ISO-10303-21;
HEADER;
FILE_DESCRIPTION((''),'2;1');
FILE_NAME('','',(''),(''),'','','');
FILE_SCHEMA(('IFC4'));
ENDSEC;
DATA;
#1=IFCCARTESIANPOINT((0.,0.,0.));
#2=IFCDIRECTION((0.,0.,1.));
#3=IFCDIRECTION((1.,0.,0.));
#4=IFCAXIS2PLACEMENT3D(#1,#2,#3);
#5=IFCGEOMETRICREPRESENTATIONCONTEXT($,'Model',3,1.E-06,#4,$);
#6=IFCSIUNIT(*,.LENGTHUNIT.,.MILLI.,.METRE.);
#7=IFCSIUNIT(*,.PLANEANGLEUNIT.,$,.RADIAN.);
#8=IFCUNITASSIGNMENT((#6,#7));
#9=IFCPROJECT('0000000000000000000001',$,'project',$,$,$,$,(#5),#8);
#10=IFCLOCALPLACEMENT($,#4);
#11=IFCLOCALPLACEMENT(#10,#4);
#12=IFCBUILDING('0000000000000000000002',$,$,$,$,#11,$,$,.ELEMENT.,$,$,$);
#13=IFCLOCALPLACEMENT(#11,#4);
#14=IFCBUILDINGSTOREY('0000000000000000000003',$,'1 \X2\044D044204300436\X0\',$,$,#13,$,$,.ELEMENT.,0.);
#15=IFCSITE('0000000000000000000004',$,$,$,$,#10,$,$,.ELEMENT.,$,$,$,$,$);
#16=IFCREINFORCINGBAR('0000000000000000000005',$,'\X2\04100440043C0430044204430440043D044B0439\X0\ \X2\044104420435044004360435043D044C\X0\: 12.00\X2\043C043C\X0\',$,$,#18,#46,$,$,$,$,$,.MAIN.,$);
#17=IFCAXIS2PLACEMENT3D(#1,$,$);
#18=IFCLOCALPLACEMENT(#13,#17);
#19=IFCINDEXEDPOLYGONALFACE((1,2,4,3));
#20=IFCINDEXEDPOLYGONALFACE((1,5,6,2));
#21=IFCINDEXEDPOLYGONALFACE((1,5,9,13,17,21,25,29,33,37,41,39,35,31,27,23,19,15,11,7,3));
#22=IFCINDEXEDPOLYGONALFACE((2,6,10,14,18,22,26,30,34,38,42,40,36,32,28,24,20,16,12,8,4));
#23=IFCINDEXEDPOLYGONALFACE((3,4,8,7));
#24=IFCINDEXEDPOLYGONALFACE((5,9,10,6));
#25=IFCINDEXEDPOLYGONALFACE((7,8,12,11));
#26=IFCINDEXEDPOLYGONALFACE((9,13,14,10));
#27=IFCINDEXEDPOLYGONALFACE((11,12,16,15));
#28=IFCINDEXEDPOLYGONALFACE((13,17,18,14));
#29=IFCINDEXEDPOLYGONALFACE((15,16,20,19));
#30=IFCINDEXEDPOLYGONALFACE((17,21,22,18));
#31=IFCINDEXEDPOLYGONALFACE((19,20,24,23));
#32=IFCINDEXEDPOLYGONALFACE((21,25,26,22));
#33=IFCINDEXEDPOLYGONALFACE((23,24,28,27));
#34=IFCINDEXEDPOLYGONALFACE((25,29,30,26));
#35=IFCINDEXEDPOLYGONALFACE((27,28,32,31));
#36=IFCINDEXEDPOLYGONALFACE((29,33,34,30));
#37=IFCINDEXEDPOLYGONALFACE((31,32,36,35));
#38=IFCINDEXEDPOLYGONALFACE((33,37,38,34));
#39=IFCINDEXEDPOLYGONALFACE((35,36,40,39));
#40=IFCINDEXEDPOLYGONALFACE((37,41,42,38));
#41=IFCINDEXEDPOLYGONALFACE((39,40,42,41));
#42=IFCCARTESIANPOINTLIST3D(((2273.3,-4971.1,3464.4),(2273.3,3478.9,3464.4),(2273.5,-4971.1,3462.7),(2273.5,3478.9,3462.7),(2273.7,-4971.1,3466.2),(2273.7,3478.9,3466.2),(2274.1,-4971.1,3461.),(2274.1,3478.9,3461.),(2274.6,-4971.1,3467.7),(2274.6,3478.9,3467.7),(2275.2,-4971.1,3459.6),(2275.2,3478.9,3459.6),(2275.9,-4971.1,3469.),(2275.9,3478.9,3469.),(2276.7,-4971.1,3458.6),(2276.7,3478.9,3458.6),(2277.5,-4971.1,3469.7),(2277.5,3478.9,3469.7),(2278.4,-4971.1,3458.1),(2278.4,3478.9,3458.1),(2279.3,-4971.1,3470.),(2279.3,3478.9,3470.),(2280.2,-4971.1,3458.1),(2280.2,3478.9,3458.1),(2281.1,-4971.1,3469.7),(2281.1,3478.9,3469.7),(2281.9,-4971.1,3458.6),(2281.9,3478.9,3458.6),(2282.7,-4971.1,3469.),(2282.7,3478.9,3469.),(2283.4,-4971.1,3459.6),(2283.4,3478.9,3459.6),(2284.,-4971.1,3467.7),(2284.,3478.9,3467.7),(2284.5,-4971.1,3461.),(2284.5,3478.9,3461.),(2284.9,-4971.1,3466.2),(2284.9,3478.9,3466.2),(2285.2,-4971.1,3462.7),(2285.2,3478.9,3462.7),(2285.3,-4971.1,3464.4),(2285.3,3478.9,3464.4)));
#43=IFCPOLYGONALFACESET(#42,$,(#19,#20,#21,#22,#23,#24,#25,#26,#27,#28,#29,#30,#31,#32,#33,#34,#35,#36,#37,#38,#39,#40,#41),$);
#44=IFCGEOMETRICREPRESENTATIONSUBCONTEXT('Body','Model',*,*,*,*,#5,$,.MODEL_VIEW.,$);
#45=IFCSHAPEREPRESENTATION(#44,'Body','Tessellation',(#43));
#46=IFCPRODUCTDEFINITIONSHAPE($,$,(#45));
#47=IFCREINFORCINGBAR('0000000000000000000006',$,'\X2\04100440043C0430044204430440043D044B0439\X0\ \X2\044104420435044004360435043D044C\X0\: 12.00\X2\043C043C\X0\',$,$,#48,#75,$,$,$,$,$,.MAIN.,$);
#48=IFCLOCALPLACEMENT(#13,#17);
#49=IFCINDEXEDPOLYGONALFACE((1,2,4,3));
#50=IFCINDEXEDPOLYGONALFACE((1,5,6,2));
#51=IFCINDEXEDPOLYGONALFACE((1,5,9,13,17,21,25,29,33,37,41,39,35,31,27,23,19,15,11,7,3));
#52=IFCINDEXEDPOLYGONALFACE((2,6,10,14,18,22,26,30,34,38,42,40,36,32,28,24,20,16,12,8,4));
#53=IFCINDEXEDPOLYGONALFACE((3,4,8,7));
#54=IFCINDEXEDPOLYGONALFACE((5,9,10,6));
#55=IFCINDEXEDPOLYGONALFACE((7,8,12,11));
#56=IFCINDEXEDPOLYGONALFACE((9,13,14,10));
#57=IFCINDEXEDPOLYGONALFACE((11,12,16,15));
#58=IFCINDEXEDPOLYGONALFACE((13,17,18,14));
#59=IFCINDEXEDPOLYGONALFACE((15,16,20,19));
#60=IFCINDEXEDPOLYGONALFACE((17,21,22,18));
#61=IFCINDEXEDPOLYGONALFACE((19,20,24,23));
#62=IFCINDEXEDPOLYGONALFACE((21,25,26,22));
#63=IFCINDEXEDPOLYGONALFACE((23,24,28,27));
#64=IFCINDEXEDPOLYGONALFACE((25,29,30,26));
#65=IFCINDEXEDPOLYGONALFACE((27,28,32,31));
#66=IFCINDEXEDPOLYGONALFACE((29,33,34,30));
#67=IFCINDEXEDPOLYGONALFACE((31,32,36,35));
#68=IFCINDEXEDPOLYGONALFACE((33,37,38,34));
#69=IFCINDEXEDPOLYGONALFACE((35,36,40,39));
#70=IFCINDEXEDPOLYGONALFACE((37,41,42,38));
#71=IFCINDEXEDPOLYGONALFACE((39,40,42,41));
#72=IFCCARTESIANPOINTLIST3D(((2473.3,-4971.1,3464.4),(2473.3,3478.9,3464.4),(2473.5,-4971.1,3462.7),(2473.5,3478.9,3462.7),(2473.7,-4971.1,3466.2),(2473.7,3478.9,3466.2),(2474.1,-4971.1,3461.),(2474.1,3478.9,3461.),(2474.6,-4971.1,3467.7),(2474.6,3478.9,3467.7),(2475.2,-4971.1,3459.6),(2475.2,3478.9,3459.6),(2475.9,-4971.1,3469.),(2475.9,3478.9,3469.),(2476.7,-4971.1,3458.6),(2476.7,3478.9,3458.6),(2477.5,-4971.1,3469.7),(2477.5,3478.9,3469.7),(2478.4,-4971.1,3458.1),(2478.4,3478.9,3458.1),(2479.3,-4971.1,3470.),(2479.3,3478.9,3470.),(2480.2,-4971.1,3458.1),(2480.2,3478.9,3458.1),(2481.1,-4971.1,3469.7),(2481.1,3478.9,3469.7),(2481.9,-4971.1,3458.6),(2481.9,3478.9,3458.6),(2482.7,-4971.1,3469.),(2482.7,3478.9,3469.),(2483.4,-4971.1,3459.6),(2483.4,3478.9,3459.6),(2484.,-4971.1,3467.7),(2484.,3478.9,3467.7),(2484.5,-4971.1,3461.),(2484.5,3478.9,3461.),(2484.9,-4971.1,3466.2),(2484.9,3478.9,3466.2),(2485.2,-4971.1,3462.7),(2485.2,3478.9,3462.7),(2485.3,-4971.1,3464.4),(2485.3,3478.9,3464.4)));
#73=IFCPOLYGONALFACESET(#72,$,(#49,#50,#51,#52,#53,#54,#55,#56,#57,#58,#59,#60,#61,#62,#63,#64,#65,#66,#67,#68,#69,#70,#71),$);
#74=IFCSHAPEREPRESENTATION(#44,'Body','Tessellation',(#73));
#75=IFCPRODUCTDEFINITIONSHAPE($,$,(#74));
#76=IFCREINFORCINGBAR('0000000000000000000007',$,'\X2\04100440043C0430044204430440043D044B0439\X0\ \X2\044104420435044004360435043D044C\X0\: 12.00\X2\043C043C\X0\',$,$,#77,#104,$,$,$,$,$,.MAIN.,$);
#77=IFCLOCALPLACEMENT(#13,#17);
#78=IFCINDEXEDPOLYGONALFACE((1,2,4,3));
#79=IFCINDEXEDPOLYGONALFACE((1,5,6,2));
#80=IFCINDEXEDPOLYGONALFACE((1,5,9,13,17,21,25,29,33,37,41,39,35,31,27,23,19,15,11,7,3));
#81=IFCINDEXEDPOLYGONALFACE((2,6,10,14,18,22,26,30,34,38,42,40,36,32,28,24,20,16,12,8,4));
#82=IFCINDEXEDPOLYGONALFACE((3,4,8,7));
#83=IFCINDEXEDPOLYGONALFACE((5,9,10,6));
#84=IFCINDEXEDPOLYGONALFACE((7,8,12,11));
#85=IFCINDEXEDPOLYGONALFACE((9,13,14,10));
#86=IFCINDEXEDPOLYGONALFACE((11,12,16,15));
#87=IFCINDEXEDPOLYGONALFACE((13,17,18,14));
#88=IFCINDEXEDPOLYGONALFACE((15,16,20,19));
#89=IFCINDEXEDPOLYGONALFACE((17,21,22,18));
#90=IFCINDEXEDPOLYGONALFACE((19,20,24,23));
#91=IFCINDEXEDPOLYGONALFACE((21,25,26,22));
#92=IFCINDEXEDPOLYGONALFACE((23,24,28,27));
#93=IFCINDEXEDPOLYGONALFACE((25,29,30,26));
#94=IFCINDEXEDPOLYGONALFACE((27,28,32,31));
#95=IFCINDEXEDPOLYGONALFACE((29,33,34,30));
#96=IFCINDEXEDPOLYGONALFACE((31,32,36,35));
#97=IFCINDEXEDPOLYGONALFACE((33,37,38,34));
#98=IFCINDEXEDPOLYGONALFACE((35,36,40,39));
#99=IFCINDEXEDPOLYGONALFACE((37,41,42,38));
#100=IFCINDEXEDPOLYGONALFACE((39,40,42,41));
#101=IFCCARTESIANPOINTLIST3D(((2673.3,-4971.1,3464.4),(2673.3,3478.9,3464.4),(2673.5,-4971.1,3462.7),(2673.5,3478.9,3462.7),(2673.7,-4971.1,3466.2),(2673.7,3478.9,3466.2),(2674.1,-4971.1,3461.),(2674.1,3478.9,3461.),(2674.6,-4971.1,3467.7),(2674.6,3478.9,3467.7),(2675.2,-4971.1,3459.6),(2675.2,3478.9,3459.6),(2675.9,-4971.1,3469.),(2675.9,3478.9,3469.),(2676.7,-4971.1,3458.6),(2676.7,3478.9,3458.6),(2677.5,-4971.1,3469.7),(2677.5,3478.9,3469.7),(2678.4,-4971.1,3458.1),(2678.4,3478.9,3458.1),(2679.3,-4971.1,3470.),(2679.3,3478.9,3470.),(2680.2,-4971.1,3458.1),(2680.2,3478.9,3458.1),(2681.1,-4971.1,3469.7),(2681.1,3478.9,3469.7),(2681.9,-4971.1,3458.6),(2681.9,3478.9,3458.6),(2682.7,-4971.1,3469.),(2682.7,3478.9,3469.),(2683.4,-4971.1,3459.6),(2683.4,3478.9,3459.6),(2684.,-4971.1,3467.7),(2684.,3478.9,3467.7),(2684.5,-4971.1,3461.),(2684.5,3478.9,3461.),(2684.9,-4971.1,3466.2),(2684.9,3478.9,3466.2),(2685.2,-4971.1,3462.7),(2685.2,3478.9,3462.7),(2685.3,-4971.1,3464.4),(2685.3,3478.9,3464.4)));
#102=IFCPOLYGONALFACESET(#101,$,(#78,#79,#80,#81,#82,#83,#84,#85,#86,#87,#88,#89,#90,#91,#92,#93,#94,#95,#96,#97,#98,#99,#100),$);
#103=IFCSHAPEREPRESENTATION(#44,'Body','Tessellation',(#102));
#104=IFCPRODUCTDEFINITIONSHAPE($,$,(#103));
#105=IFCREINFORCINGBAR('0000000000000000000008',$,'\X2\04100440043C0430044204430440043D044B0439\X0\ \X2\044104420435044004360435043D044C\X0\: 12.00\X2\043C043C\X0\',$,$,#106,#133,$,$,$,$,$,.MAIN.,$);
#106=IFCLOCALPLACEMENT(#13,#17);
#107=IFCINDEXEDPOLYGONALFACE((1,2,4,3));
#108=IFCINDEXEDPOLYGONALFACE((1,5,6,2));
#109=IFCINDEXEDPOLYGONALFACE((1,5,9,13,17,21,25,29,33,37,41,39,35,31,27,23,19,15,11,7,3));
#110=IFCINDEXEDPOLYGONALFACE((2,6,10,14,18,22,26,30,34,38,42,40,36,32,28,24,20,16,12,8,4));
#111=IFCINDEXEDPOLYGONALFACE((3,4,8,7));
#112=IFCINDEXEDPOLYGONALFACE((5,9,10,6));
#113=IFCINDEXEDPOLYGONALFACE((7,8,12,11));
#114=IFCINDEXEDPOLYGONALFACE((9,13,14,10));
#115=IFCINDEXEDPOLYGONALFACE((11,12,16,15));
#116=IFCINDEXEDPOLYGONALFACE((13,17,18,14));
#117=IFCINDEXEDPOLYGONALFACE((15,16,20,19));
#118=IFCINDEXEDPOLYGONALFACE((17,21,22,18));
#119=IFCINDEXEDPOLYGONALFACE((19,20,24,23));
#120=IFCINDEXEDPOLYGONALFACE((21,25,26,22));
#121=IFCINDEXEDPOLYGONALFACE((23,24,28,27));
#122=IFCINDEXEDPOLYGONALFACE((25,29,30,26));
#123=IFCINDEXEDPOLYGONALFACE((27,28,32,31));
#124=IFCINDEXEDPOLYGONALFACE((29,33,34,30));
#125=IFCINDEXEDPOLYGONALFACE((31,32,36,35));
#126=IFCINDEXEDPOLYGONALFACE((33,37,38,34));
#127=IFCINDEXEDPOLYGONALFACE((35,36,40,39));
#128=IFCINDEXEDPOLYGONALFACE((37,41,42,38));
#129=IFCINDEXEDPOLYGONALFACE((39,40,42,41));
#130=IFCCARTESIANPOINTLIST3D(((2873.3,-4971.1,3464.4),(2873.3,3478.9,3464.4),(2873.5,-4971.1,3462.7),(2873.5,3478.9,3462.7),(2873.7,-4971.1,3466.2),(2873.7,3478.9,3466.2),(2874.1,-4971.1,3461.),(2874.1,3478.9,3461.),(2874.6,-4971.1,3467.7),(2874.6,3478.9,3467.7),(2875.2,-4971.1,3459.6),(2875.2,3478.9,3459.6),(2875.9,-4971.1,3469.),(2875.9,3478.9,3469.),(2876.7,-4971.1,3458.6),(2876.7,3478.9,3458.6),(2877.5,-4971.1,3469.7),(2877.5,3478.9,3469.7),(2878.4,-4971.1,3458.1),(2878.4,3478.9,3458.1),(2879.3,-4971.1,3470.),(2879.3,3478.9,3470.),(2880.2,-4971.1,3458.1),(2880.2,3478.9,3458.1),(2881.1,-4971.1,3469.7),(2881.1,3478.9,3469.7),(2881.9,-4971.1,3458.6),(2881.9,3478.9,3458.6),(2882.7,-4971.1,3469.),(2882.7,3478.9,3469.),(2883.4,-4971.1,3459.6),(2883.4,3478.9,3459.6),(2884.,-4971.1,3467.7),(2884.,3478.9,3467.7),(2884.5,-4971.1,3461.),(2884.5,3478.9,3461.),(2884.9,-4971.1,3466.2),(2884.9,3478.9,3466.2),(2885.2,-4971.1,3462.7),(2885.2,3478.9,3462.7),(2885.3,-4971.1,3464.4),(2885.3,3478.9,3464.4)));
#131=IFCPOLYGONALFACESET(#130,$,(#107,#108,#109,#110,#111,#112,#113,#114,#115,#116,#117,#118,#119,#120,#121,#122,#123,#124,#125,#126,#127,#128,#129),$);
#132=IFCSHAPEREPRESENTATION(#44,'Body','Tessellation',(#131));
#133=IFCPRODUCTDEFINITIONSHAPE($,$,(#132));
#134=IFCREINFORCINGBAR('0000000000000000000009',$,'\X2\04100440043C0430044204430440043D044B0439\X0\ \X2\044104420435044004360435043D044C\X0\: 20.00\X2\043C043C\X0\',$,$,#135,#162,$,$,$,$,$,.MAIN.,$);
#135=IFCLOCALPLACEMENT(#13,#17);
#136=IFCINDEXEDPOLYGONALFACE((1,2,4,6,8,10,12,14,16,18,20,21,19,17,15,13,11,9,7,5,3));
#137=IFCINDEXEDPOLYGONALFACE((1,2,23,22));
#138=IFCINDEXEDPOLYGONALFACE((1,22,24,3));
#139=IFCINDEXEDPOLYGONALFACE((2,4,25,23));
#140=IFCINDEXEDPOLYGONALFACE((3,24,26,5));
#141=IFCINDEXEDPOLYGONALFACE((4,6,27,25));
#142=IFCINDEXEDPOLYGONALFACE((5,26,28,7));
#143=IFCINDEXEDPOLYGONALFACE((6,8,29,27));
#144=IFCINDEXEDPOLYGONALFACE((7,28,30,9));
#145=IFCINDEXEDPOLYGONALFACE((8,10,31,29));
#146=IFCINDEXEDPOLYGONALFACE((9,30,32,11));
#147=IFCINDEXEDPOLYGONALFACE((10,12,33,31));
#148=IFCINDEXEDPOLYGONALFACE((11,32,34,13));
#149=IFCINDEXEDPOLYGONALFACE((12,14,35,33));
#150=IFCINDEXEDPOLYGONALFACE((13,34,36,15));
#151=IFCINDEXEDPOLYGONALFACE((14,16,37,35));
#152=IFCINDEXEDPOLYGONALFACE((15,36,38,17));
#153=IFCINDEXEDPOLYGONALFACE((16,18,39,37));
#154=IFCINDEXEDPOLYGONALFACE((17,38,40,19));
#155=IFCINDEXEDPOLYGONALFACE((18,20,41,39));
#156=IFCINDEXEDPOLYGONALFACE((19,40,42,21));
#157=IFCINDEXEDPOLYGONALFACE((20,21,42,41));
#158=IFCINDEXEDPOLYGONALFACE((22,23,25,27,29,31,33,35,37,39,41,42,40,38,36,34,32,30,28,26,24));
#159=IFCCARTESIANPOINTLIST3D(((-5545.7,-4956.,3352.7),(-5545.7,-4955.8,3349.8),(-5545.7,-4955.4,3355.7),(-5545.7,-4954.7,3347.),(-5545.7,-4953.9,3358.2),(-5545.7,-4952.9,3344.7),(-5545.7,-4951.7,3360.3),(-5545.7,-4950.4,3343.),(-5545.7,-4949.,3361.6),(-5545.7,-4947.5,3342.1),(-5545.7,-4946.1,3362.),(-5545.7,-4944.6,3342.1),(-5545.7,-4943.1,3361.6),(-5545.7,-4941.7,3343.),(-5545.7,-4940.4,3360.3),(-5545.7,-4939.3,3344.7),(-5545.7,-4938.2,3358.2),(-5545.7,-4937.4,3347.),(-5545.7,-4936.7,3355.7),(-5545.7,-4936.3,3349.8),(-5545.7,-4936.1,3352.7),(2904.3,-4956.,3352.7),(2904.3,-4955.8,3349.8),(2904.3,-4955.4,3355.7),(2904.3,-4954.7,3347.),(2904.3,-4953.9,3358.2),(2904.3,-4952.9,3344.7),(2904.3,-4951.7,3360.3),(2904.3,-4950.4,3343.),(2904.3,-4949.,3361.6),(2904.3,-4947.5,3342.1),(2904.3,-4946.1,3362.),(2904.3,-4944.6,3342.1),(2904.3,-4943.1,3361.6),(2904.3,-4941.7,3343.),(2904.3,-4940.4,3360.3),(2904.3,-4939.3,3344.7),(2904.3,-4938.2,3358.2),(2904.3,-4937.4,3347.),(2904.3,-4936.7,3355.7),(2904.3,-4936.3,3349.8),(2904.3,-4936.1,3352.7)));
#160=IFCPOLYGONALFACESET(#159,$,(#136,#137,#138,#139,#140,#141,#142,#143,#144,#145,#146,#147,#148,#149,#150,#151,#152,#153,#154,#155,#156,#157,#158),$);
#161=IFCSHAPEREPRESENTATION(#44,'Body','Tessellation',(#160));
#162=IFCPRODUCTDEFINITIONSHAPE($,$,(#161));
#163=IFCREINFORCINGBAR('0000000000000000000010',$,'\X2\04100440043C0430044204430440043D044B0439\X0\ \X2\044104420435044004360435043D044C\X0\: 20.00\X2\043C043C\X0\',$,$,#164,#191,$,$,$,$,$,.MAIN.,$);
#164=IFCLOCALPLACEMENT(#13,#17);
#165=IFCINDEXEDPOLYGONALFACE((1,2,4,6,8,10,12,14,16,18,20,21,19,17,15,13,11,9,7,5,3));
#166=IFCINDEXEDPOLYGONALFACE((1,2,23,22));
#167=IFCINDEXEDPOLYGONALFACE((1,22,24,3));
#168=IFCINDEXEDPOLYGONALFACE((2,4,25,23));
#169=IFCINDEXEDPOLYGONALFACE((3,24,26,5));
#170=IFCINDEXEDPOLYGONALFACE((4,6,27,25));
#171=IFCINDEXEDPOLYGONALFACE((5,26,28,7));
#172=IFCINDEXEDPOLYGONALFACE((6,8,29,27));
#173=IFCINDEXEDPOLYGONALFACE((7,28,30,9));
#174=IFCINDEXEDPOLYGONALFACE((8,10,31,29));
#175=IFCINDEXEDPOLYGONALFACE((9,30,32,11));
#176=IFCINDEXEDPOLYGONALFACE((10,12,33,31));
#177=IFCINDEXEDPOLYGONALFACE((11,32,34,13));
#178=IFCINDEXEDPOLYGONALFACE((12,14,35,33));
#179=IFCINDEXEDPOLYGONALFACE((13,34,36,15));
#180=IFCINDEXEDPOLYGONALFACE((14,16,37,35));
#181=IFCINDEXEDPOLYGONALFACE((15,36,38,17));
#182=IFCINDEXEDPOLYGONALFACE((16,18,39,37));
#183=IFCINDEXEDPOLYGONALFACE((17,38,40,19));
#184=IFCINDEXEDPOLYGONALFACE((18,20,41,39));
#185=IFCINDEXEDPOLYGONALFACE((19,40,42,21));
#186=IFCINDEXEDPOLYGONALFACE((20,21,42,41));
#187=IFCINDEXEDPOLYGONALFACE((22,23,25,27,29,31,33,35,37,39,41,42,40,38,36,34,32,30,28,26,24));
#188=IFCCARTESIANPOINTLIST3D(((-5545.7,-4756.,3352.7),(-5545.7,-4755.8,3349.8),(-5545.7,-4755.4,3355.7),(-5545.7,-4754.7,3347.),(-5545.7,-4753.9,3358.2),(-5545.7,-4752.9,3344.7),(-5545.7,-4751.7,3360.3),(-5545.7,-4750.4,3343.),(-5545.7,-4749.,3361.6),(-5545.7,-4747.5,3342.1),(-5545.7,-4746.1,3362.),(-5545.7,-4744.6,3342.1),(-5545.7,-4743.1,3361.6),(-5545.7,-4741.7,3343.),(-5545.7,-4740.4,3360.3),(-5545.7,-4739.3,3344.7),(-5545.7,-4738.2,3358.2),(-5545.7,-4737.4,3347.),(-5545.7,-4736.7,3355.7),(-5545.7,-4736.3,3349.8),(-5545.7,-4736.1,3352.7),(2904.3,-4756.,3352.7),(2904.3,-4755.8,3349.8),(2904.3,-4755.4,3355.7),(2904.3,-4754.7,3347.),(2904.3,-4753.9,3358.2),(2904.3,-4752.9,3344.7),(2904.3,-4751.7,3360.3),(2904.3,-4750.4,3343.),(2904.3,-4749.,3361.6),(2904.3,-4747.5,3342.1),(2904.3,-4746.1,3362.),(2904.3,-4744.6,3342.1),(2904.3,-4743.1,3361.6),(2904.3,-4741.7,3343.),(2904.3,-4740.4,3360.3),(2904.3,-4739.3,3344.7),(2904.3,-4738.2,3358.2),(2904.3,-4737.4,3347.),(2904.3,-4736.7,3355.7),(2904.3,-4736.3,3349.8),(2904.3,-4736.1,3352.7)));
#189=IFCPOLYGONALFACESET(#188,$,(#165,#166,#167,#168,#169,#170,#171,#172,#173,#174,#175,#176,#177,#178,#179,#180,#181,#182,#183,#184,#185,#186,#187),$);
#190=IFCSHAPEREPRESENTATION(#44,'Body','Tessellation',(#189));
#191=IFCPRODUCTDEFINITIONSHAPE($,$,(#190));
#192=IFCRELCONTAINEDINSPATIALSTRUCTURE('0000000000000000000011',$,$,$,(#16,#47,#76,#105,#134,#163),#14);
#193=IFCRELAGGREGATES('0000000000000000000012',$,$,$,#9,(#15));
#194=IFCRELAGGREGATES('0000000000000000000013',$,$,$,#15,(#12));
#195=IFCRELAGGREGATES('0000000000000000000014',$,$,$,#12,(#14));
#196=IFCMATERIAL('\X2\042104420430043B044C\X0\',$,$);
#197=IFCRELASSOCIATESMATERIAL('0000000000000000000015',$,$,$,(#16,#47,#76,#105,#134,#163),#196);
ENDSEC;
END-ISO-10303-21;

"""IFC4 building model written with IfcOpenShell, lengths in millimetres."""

from ifc_helpers import new_model, entity, si_unit, origin_with_axes, place, context, subcontext, project, spatial, source, transform, mapped, material, element, save


model = new_model("IFC4")

# Units and contexts
model_context = context("Model", 3, precision=1e-06, world=origin_with_axes())
body_context = subcontext(model_context, "Body", "Model", "MODEL_VIEW")
ifc_project = project(units=[si_unit("LENGTHUNIT", "METRE", prefix="MILLI"), si_unit("PLANEANGLEUNIT", "RADIAN")], contexts=[model_context])

# Site, building, storey
site_placement = place(None, origin_with_axes())
site = spatial("IfcSite", under=ifc_project, at=site_placement, CompositionType="ELEMENT")
building_placement = place(site_placement, origin_with_axes())
building = spatial("IfcBuilding", under=site, at=building_placement, CompositionType="ELEMENT")
storey_placement = place(building_placement, origin_with_axes())
storey = spatial("IfcBuildingStorey", under=building, at=storey_placement, Name="1 этаж", CompositionType="ELEMENT", Elevation=0.0)

# Shared definitions
ifc_material_1 = material(Name="Сталь")

# Reinforcing bars
shared_shape_1 = source(origin_with_axes(), body_context, "Body", "AdvancedSweptSolid", [
    entity("IfcSweptDiskSolid", entity("IfcIndexedPolyCurve", entity("IfcCartesianPointList3D", [[0.0, 0.0, 0.0], [8450.0, 0.0, 0.0]]), [entity("IfcLineIndex", [1, 2])]), 6.0),
])
reinforcing_bar_1_placement = place(storey_placement, origin_with_axes())
element("IfcReinforcingBar", 1, at=reinforcing_bar_1_placement, inside=storey, material=ifc_material_1, Name="Арматурный стержень: 12.00мм", PredefinedType="MAIN", context=body_context, shape_type="MappedRepresentation", body=[
    mapped(shared_shape_1, transform((2279.3, -4971.1, 3464.0), x_axis=(0.0, 1.0, 0.0), y_axis=(-1.0, 0.0, 0.0), z_axis=(0.0, 0.0, 1.0), scale=1.0)),
])
reinforcing_bar_2_placement = place(storey_placement, origin_with_axes())
element("IfcReinforcingBar", 2, at=reinforcing_bar_2_placement, inside=storey, material=ifc_material_1, Name="Арматурный стержень: 12.00мм", PredefinedType="MAIN", context=body_context, shape_type="MappedRepresentation", body=[
    mapped(shared_shape_1, transform((2479.3, -4971.1, 3464.0), x_axis=(0.0, 1.0, 0.0), y_axis=(-1.0, 0.0, 0.0), z_axis=(0.0, 0.0, 1.0), scale=1.0)),
])
reinforcing_bar_3_placement = place(storey_placement, origin_with_axes())
element("IfcReinforcingBar", 3, at=reinforcing_bar_3_placement, inside=storey, material=ifc_material_1, Name="Арматурный стержень: 12.00мм", PredefinedType="MAIN", context=body_context, shape_type="MappedRepresentation", body=[
    mapped(shared_shape_1, transform((2679.3, -4971.1, 3464.0), x_axis=(0.0, 1.0, 0.0), y_axis=(-1.0, 0.0, 0.0), z_axis=(0.0, 0.0, 1.0), scale=1.0)),
])
reinforcing_bar_4_placement = place(storey_placement, origin_with_axes())
element("IfcReinforcingBar", 4, at=reinforcing_bar_4_placement, inside=storey, material=ifc_material_1, Name="Арматурный стержень: 12.00мм", PredefinedType="MAIN", context=body_context, shape_type="MappedRepresentation", body=[
    mapped(shared_shape_1, transform((2879.3, -4971.1, 3464.0), x_axis=(0.0, 1.0, 0.0), y_axis=(-1.0, 0.0, 0.0), z_axis=(0.0, 0.0, 1.0), scale=1.0)),
])
shared_shape_2 = source(origin_with_axes(), body_context, "Body", "AdvancedSweptSolid", [
    entity("IfcSweptDiskSolid", entity("IfcIndexedPolyCurve", entity("IfcCartesianPointList3D", [[0.0, 0.0, 0.0], [8450.0, 0.0, 0.0]]), [entity("IfcLineIndex", [1, 2])]), 10.0),
])
reinforcing_bar_5_placement = place(storey_placement, origin_with_axes())
element("IfcReinforcingBar", 5, at=reinforcing_bar_5_placement, inside=storey, material=ifc_material_1, Name="Арматурный стержень: 20.00мм", PredefinedType="MAIN", context=body_context, shape_type="MappedRepresentation", body=[
    mapped(shared_shape_2, transform((-5545.7, -4946.1, 3352.0), x_axis=(1.0, 0.0, 0.0), y_axis=(0.0, 1.0, 0.0), z_axis=(0.0, 0.0, 1.0), scale=1.0)),
])
reinforcing_bar_6_placement = place(storey_placement, origin_with_axes())
element("IfcReinforcingBar", 6, at=reinforcing_bar_6_placement, inside=storey, material=ifc_material_1, Name="Арматурный стержень: 20.00мм", PredefinedType="MAIN", context=body_context, shape_type="MappedRepresentation", body=[
    mapped(shared_shape_2, transform((-5545.7, -4746.1, 3352.0), x_axis=(1.0, 0.0, 0.0), y_axis=(0.0, 1.0, 0.0), z_axis=(0.0, 0.0, 1.0), scale=1.0)),
])

save(model, "model.ifc")
